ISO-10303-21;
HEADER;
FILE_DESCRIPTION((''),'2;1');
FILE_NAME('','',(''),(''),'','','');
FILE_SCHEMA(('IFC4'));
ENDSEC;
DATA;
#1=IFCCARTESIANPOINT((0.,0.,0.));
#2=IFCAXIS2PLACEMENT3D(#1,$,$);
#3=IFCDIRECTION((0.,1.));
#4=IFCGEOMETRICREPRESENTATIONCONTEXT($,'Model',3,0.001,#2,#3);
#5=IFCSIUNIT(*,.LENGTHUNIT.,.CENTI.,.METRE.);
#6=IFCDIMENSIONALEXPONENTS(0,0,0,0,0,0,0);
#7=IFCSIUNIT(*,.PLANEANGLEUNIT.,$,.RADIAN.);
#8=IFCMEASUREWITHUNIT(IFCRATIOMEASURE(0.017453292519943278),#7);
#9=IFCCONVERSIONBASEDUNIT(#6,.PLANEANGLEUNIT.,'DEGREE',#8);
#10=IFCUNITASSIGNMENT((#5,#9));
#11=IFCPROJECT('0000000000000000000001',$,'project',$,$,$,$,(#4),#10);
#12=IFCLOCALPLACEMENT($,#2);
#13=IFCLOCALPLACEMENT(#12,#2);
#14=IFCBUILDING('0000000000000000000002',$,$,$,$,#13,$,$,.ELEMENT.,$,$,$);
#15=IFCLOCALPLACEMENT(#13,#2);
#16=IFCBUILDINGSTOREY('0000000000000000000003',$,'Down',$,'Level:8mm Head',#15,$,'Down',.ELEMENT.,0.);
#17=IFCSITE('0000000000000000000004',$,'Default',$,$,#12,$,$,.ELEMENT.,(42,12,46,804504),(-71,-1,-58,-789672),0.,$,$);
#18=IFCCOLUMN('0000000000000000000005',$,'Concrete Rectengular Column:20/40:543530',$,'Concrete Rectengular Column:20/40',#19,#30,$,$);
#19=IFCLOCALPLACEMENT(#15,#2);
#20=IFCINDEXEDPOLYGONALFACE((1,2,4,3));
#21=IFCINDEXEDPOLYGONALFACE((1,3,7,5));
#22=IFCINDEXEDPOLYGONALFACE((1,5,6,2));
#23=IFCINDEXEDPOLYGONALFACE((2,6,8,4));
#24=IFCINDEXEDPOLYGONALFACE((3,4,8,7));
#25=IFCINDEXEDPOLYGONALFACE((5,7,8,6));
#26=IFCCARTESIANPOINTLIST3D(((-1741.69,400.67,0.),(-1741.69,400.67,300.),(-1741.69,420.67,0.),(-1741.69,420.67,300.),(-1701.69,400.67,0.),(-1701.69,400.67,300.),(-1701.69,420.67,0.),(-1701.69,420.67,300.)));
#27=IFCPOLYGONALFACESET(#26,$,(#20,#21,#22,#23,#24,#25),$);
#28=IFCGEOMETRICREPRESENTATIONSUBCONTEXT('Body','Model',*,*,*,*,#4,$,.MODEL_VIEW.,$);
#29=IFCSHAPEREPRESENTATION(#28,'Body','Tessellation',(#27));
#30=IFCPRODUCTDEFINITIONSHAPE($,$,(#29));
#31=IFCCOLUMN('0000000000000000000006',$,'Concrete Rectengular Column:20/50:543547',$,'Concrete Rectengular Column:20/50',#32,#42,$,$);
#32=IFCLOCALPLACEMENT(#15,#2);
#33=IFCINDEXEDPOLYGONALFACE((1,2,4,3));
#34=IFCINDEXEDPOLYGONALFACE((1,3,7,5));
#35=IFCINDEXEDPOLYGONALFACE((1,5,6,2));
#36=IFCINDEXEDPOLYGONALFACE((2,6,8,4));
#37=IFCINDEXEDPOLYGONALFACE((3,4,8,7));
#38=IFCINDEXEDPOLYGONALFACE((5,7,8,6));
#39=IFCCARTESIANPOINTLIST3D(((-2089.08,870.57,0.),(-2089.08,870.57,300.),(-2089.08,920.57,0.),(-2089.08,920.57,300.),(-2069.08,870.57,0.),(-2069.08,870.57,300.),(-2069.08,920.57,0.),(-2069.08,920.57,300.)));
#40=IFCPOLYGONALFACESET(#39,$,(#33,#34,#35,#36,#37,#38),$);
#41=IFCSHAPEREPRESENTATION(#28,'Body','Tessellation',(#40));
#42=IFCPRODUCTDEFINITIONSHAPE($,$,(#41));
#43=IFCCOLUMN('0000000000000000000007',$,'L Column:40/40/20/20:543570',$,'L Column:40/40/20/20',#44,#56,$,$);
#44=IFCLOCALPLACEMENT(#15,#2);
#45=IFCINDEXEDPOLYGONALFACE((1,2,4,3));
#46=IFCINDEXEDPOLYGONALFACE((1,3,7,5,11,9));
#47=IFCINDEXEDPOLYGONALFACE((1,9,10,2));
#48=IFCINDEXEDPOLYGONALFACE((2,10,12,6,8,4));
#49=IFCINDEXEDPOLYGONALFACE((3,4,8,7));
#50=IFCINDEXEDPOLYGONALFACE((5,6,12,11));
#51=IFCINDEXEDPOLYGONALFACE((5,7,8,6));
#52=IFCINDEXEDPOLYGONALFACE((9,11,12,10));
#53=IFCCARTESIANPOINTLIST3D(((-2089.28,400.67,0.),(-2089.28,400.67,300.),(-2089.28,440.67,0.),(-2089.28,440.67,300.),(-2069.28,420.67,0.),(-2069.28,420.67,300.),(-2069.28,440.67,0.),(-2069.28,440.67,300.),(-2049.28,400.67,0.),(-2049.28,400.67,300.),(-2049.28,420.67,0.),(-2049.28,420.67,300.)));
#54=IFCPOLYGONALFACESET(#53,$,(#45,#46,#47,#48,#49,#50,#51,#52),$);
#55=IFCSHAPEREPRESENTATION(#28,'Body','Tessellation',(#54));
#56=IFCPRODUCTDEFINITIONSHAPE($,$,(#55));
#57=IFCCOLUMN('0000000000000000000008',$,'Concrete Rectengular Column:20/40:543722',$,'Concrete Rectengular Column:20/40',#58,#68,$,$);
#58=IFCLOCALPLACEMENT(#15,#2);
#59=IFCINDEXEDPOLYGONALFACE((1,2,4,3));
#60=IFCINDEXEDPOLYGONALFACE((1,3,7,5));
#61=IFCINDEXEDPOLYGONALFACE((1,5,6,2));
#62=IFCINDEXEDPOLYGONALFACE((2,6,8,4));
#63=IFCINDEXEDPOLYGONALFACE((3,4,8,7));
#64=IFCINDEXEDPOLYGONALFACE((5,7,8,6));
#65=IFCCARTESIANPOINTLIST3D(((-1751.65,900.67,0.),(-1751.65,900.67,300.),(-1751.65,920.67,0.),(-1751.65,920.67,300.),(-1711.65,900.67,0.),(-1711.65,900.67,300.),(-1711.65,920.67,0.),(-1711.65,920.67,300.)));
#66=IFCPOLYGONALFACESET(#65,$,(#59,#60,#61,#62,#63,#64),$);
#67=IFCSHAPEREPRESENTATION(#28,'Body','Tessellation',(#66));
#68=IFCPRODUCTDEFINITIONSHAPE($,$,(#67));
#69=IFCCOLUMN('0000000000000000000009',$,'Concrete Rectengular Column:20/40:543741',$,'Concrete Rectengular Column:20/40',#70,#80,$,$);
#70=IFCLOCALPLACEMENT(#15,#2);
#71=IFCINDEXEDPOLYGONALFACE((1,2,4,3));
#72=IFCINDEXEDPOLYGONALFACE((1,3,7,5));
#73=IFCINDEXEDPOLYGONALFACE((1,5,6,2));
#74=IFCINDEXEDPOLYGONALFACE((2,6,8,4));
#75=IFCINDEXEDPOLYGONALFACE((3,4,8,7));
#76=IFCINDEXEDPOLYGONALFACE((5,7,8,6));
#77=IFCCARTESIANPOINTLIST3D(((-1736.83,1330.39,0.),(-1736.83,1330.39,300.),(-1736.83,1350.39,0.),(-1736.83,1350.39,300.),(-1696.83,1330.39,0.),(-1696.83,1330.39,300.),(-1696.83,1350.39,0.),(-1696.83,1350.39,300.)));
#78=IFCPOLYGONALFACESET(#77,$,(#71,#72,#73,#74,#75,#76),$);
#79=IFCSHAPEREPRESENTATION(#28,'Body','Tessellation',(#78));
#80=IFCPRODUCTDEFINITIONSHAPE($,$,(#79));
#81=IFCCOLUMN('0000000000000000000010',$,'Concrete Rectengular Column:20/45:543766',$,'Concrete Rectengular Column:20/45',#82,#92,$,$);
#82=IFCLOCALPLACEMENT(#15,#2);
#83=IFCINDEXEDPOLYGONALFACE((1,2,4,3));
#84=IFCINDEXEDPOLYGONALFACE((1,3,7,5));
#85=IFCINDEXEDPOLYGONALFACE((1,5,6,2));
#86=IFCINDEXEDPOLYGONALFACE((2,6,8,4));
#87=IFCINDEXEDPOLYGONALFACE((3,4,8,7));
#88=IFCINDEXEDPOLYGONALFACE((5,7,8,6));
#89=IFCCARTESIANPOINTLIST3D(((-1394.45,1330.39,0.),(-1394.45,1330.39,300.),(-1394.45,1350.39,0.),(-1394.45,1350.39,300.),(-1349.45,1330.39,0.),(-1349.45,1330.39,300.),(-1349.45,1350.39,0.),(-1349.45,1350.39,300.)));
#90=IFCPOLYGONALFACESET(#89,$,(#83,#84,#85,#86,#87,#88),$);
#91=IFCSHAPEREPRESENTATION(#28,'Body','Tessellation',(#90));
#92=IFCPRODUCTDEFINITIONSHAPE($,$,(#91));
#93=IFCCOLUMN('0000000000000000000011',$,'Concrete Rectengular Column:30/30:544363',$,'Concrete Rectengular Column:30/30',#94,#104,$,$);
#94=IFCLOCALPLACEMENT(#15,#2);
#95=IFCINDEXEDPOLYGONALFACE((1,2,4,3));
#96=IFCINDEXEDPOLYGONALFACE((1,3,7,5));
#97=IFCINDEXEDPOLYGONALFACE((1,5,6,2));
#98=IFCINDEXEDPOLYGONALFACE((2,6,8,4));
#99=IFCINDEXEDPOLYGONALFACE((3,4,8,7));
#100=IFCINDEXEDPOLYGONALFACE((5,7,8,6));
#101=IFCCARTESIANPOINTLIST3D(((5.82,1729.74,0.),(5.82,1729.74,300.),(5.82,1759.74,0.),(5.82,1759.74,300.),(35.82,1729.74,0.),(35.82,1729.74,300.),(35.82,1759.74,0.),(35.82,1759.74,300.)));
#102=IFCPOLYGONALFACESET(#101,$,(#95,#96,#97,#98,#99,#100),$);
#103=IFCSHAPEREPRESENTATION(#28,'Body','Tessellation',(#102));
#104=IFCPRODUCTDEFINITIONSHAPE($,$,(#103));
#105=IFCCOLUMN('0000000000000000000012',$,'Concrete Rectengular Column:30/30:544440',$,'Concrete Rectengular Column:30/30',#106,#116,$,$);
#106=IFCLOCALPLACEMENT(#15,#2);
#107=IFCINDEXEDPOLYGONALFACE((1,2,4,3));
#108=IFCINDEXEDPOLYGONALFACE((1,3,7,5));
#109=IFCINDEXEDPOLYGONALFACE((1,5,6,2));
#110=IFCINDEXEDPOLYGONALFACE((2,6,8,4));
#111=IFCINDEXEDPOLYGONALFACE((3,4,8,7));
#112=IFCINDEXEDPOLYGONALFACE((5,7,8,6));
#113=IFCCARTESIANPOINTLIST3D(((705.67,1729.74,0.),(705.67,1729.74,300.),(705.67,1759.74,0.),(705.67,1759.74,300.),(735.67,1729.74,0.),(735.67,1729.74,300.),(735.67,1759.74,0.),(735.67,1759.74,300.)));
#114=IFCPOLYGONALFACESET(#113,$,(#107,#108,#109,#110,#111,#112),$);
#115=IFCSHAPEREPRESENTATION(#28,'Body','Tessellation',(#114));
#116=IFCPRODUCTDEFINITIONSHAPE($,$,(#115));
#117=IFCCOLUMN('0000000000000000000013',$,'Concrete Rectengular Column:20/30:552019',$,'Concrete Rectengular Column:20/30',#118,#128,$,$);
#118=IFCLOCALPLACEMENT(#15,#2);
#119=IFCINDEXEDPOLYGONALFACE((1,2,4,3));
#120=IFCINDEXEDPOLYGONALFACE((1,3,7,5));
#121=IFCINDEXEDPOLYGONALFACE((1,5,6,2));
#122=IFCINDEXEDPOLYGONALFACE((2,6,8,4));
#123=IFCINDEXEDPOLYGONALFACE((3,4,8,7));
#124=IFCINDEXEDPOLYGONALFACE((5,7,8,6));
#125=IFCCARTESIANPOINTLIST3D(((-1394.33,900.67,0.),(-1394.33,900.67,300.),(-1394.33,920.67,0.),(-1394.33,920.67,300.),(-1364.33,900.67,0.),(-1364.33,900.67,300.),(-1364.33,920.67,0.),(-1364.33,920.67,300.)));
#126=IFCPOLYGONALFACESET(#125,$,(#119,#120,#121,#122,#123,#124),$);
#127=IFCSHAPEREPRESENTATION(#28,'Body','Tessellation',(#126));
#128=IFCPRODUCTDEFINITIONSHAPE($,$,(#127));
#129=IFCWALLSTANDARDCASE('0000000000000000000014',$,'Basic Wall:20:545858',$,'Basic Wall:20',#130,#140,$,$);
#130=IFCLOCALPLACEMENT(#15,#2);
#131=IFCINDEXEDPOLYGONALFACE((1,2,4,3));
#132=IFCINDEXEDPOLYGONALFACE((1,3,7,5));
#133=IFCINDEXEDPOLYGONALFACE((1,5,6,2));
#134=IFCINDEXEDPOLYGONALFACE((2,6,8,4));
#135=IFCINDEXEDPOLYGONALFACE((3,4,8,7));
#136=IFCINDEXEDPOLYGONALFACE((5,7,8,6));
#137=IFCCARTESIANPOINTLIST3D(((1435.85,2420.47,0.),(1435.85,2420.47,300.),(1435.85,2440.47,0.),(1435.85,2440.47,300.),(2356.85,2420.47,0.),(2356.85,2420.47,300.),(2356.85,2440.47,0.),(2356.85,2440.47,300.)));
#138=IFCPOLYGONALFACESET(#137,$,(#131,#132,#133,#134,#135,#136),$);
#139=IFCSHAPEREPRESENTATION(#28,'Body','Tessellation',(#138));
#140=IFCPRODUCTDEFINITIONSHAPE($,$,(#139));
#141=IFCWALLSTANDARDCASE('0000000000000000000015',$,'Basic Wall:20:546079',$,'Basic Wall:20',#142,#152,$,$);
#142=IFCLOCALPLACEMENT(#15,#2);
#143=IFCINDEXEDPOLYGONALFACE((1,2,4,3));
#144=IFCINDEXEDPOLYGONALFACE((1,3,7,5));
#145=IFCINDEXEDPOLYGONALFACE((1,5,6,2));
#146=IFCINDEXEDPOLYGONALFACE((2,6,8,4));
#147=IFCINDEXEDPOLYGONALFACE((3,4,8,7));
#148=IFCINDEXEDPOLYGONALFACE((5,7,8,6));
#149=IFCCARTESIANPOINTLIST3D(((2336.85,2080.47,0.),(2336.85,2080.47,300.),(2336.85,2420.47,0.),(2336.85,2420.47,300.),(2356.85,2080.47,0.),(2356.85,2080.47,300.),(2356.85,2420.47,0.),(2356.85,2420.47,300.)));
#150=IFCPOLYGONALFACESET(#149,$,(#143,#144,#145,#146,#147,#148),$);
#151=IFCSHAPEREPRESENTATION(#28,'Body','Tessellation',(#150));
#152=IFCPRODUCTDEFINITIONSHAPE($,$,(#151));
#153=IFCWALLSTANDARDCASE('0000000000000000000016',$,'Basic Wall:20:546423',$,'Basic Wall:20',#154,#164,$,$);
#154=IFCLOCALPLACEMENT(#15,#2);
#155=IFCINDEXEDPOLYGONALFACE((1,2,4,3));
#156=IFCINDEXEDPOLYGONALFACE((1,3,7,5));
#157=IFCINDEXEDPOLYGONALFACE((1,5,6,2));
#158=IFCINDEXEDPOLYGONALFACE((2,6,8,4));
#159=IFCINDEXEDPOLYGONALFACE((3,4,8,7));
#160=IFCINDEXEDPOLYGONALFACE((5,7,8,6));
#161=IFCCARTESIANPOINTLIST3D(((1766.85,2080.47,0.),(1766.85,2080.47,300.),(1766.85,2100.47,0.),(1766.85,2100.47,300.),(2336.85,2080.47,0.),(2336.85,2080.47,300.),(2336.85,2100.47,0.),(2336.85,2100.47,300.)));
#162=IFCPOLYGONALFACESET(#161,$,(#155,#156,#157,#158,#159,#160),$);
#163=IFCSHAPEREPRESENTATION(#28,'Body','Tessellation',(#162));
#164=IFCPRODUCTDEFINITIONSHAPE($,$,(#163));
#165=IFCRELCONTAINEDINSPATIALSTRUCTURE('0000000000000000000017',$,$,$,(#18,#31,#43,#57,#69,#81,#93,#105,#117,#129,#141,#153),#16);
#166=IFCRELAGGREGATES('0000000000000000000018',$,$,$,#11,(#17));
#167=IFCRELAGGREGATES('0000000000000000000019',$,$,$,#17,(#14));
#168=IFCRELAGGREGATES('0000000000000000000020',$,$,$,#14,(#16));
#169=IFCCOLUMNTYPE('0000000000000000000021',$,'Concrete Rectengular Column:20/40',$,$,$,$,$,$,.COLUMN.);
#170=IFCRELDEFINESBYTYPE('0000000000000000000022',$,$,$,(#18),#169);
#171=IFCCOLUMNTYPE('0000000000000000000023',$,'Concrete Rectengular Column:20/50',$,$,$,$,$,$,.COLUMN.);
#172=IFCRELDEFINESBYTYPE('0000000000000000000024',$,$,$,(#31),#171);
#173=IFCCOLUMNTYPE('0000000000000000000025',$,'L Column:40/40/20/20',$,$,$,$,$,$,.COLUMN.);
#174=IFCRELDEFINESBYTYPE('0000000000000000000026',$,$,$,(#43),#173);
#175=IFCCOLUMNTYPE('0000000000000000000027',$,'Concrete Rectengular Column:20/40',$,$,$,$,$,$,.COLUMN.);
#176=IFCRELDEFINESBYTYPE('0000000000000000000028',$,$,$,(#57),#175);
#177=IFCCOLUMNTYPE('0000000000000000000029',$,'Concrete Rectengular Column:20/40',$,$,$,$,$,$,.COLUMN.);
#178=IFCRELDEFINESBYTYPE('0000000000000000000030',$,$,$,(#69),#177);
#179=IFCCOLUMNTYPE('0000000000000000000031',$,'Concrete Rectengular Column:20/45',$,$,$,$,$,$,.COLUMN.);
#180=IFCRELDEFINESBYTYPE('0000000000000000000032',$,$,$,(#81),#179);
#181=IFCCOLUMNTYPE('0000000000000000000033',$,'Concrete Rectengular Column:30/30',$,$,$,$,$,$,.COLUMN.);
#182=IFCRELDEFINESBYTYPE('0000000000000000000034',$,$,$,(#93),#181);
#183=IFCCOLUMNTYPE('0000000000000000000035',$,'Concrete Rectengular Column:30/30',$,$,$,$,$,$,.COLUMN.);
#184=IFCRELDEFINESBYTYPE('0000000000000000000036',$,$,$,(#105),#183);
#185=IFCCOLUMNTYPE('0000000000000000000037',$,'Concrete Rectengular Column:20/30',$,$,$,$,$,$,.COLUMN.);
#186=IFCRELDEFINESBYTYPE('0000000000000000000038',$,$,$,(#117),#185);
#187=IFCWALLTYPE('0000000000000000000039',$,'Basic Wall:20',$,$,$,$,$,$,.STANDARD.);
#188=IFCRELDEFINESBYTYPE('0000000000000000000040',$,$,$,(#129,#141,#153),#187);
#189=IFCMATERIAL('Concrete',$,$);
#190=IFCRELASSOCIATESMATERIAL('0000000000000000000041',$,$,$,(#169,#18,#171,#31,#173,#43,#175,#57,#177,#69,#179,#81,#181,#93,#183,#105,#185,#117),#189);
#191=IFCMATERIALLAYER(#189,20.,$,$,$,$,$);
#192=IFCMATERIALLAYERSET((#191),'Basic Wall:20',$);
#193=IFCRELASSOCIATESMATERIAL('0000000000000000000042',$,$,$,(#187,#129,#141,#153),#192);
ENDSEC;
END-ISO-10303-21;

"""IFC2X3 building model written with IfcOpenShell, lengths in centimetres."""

from ifc_helpers import new_model, entity, si_unit, converted_unit, direction, frame, frame_2d, origin, origin_2d_with_axis, place, context, subcontext, project, spatial, polyline, rectangle, outline, extrude, source, transform, mapped, material, layer, layer_set, layer_usage, type_object, type_shapes, element, save


model = new_model("IFC2X3")

# Units and contexts
model_context = context("Model", 3, precision=0.001, world=origin(), true_north=direction((0.0, 1.0)))
body_context = subcontext(model_context, "Body", "Model", "MODEL_VIEW")
ifc_project = project(units=[si_unit("LENGTHUNIT", "METRE", prefix="CENTI"), converted_unit("PLANEANGLEUNIT", "DEGREE", entity("IfcRatioMeasure", 0.017453292519943278), si_unit("PLANEANGLEUNIT", "RADIAN"), dimensions=[0, 0, 0, 0, 0, 0, 0])], contexts=[model_context])

# Site, building, storey
site_placement = place(None, origin())
site = spatial("IfcSite", under=ifc_project, at=site_placement, Name="Default", CompositionType="ELEMENT", RefLatitude=(42, 12, 46, 804504), RefLongitude=(-71, -1, -58, -789672), RefElevation=0.0)
building_placement = place(site_placement, origin())
building = spatial("IfcBuilding", under=site, at=building_placement, CompositionType="ELEMENT")
storey_placement = place(building_placement, origin())
storey = spatial("IfcBuildingStorey", under=building, at=storey_placement, Name="Down", ObjectType="Level:8mm Head", LongName="Down", CompositionType="ELEMENT", Elevation=0.0)

# Columns
ifc_material = material(Name="Concrete")
column_type_1 = type_object("IfcColumnType", Name="Concrete Rectengular Column:20/40", PredefinedType="COLUMN", material=ifc_material)
shared_shape_1 = source(origin(), body_context, "Body", "SweptSolid", [
    extrude(rectangle(XDim=20.0, YDim=40.0, at=frame_2d((0.0, 0.0), x_axis=(1.0, 0.0))), frame((-1721.69, 410.67, 0.0), z_axis=(0.0, 0.0, 1.0), x_axis=(0.0, -1.0, 0.0)), (0.0, 0.0, 1.0), 300.0),
])
type_shapes(column_type_1, [shared_shape_1])
column_1_placement = place(storey_placement, origin())
element("IfcColumn", 1, at=column_1_placement, inside=storey, type_object=column_type_1, material=ifc_material, Name="Concrete Rectengular Column:20/40:543530", ObjectType="Concrete Rectengular Column:20/40", context=body_context, shape_type="MappedRepresentation", body=[
    mapped(shared_shape_1, transform((0.0, 0.0, 0.0), scale=1.0)),
])
column_type_2 = type_object("IfcColumnType", Name="Concrete Rectengular Column:20/50", PredefinedType="COLUMN", material=ifc_material)
shared_shape_2 = source(origin(), body_context, "Body", "SweptSolid", [
    extrude(rectangle(XDim=50.0, YDim=20.0, at=origin_2d_with_axis()), frame((-2079.08, 895.57, 0.0), z_axis=(0.0, 0.0, 1.0), x_axis=(0.0, -1.0, 0.0)), (0.0, 0.0, 1.0), 300.0),
])
type_shapes(column_type_2, [shared_shape_2])
column_2_placement = place(storey_placement, origin())
element("IfcColumn", 2, at=column_2_placement, inside=storey, type_object=column_type_2, material=ifc_material, Name="Concrete Rectengular Column:20/50:543547", ObjectType="Concrete Rectengular Column:20/50", context=body_context, shape_type="MappedRepresentation", body=[
    mapped(shared_shape_2, transform((0.0, 0.0, 0.0), scale=1.0)),
])
column_type_3 = type_object("IfcColumnType", Name="L Column:40/40/20/20", PredefinedType="COLUMN", material=ifc_material)
shared_shape_3 = source(origin(), body_context, "Body", "SweptSolid", [
    extrude(outline(polyline([(-20.0, -20.0), (20.0, -20.0), (20.0, 20.0), (0.0, 20.0), (0.0, 0.0), (-20.0, 0.0), (-20.0, -20.0)])), frame((-2069.28, 420.67, 0.0), z_axis=(0.0, 0.0, 1.0), x_axis=(0.0, -1.0, 0.0)), (0.0, 0.0, 1.0), 300.0),
])
type_shapes(column_type_3, [shared_shape_3])
column_3_placement = place(storey_placement, origin())
element("IfcColumn", 3, at=column_3_placement, inside=storey, type_object=column_type_3, material=ifc_material, Name="L Column:40/40/20/20:543570", ObjectType="L Column:40/40/20/20", context=body_context, shape_type="MappedRepresentation", body=[
    mapped(shared_shape_3, transform((0.0, 0.0, 0.0), scale=1.0)),
])
column_type_4 = type_object("IfcColumnType", Name="Concrete Rectengular Column:20/40", PredefinedType="COLUMN", material=ifc_material)
shared_shape_4 = source(origin(), body_context, "Body", "SweptSolid", [
    extrude(rectangle(XDim=20.0, YDim=40.0, at=origin_2d_with_axis()), frame((-1731.65, 910.67, 0.0), z_axis=(0.0, 0.0, 1.0), x_axis=(0.0, -1.0, 0.0)), (0.0, 0.0, 1.0), 300.0),
])
type_shapes(column_type_4, [shared_shape_4])
column_4_placement = place(storey_placement, origin())
element("IfcColumn", 4, at=column_4_placement, inside=storey, type_object=column_type_4, material=ifc_material, Name="Concrete Rectengular Column:20/40:543722", ObjectType="Concrete Rectengular Column:20/40", context=body_context, shape_type="MappedRepresentation", body=[
    mapped(shared_shape_4, transform((0.0, 0.0, 0.0), scale=1.0)),
])
column_type_5 = type_object("IfcColumnType", Name="Concrete Rectengular Column:20/40", PredefinedType="COLUMN", material=ifc_material)
shared_shape_5 = source(origin(), body_context, "Body", "SweptSolid", [
    extrude(rectangle(XDim=20.0, YDim=40.0, at=frame_2d((0.0, 0.0), x_axis=(1.0, 0.0))), frame((-1716.83, 1340.39, 0.0), z_axis=(0.0, 0.0, 1.0), x_axis=(0.0, -1.0, 0.0)), (0.0, 0.0, 1.0), 300.0),
])
type_shapes(column_type_5, [shared_shape_5])
column_5_placement = place(storey_placement, origin())
element("IfcColumn", 5, at=column_5_placement, inside=storey, type_object=column_type_5, material=ifc_material, Name="Concrete Rectengular Column:20/40:543741", ObjectType="Concrete Rectengular Column:20/40", context=body_context, shape_type="MappedRepresentation", body=[
    mapped(shared_shape_5, transform((0.0, 0.0, 0.0), scale=1.0)),
])
column_type_6 = type_object("IfcColumnType", Name="Concrete Rectengular Column:20/45", PredefinedType="COLUMN", material=ifc_material)
shared_shape_6 = source(origin(), body_context, "Body", "SweptSolid", [
    extrude(rectangle(XDim=20.0, YDim=45.0, at=frame_2d((0.0, 0.0), x_axis=(1.0, 0.0))), frame((-1371.95, 1340.39, 0.0), z_axis=(0.0, 0.0, 1.0), x_axis=(0.0, -1.0, 0.0)), (0.0, 0.0, 1.0), 300.0),
])
type_shapes(column_type_6, [shared_shape_6])
column_6_placement = place(storey_placement, origin())
element("IfcColumn", 6, at=column_6_placement, inside=storey, type_object=column_type_6, material=ifc_material, Name="Concrete Rectengular Column:20/45:543766", ObjectType="Concrete Rectengular Column:20/45", context=body_context, shape_type="MappedRepresentation", body=[
    mapped(shared_shape_6, transform((0.0, 0.0, 0.0), scale=1.0)),
])
column_type_7 = type_object("IfcColumnType", Name="Concrete Rectengular Column:30/30", PredefinedType="COLUMN", material=ifc_material)
shared_shape_7 = source(origin(), body_context, "Body", "SweptSolid", [
    extrude(rectangle(XDim=30.0, YDim=30.0, at=frame_2d((0.0, 0.0), x_axis=(1.0, 0.0))), frame((20.82, 1744.74, 0.0), z_axis=(0.0, 0.0, 1.0), x_axis=(0.0, -1.0, 0.0)), (0.0, 0.0, 1.0), 300.0),
])
type_shapes(column_type_7, [shared_shape_7])
column_7_placement = place(storey_placement, origin())
element("IfcColumn", 7, at=column_7_placement, inside=storey, type_object=column_type_7, material=ifc_material, Name="Concrete Rectengular Column:30/30:544363", ObjectType="Concrete Rectengular Column:30/30", context=body_context, shape_type="MappedRepresentation", body=[
    mapped(shared_shape_7, transform((0.0, 0.0, 0.0), scale=1.0)),
])
column_type_8 = type_object("IfcColumnType", Name="Concrete Rectengular Column:30/30", PredefinedType="COLUMN", material=ifc_material)
shared_shape_8 = source(origin(), body_context, "Body", "SweptSolid", [
    extrude(rectangle(XDim=30.0, YDim=30.0, at=frame_2d((0.0, 0.0), x_axis=(1.0, 0.0))), frame((720.67, 1744.74, 0.0), z_axis=(0.0, 0.0, 1.0), x_axis=(0.0, -1.0, 0.0)), (0.0, 0.0, 1.0), 300.0),
])
type_shapes(column_type_8, [shared_shape_8])
column_8_placement = place(storey_placement, origin())
element("IfcColumn", 8, at=column_8_placement, inside=storey, type_object=column_type_8, material=ifc_material, Name="Concrete Rectengular Column:30/30:544440", ObjectType="Concrete Rectengular Column:30/30", context=body_context, shape_type="MappedRepresentation", body=[
    mapped(shared_shape_8, transform((0.0, 0.0, 0.0), scale=1.0)),
])
column_type_9 = type_object("IfcColumnType", Name="Concrete Rectengular Column:20/30", PredefinedType="COLUMN", material=ifc_material)
shared_shape_9 = source(origin(), body_context, "Body", "SweptSolid", [
    extrude(rectangle(XDim=20.0, YDim=30.0, at=origin_2d_with_axis()), frame((-1379.33, 910.67, 0.0), z_axis=(0.0, 0.0, 1.0), x_axis=(0.0, -1.0, 0.0)), (0.0, 0.0, 1.0), 300.0),
])
type_shapes(column_type_9, [shared_shape_9])
column_9_placement = place(storey_placement, origin())
element("IfcColumn", 9, at=column_9_placement, inside=storey, type_object=column_type_9, material=ifc_material, Name="Concrete Rectengular Column:20/30:552019", ObjectType="Concrete Rectengular Column:20/30", context=body_context, shape_type="MappedRepresentation", body=[
    mapped(shared_shape_9, transform((0.0, 0.0, 0.0), scale=1.0)),
])

# Walls
ifc_layer_1 = layer(ifc_material, 20.0)
ifc_layer_set_1 = layer_set([ifc_layer_1], Name="Basic Wall:20")
ifc_layer_usage_1 = layer_usage(ifc_layer_set_1, "AXIS2", "NEGATIVE", 10.0)
wall_type_1 = type_object("IfcWallType", Name="Basic Wall:20", PredefinedType="STANDARD", material=ifc_layer_set_1)
wall_1_placement = place(storey_placement, frame((1435.85, 2430.47, 0.0)))
element("IfcWallStandardCase", 10, at=wall_1_placement, inside=storey, type_object=wall_type_1, material=ifc_layer_usage_1, Name="Basic Wall:20:545858", ObjectType="Basic Wall:20", context=body_context, shape_type="SweptSolid", body=[
    extrude(rectangle(XDim=921.0, YDim=20.0, at=frame_2d((460.5, 0.0), x_axis=(-1.0, 0.0))), origin(), (0.0, 0.0, 1.0), 300.0),
])
ifc_layer_usage_2 = layer_usage(ifc_layer_set_1, "AXIS2", "NEGATIVE", 10.0)
wall_2_placement = place(storey_placement, frame((2346.85, 2420.47, 0.0), z_axis=(0.0, 0.0, 1.0), x_axis=(0.0, -1.0, 0.0)))
element("IfcWallStandardCase", 11, at=wall_2_placement, inside=storey, type_object=wall_type_1, material=ifc_layer_usage_2, Name="Basic Wall:20:546079", ObjectType="Basic Wall:20", context=body_context, shape_type="SweptSolid", body=[
    extrude(rectangle(XDim=340.0, YDim=20.0, at=frame_2d((170.0, 0.0), x_axis=(-1.0, 0.0))), origin(), (0.0, 0.0, 1.0), 300.0),
])
ifc_layer_usage_3 = layer_usage(ifc_layer_set_1, "AXIS2", "NEGATIVE", 10.0)
wall_3_placement = place(storey_placement, frame((2336.85, 2090.47, 0.0), z_axis=(0.0, 0.0, 1.0), x_axis=(-1.0, 0.0, 0.0)))
element("IfcWallStandardCase", 12, at=wall_3_placement, inside=storey, type_object=wall_type_1, material=ifc_layer_usage_3, Name="Basic Wall:20:546423", ObjectType="Basic Wall:20", context=body_context, shape_type="SweptSolid", body=[
    extrude(rectangle(XDim=570.0, YDim=20.0, at=frame_2d((285.0, 0.0), x_axis=(-1.0, 0.0))), origin(), (0.0, 0.0, 1.0), 300.0),
])

save(model, "model.ifc")
